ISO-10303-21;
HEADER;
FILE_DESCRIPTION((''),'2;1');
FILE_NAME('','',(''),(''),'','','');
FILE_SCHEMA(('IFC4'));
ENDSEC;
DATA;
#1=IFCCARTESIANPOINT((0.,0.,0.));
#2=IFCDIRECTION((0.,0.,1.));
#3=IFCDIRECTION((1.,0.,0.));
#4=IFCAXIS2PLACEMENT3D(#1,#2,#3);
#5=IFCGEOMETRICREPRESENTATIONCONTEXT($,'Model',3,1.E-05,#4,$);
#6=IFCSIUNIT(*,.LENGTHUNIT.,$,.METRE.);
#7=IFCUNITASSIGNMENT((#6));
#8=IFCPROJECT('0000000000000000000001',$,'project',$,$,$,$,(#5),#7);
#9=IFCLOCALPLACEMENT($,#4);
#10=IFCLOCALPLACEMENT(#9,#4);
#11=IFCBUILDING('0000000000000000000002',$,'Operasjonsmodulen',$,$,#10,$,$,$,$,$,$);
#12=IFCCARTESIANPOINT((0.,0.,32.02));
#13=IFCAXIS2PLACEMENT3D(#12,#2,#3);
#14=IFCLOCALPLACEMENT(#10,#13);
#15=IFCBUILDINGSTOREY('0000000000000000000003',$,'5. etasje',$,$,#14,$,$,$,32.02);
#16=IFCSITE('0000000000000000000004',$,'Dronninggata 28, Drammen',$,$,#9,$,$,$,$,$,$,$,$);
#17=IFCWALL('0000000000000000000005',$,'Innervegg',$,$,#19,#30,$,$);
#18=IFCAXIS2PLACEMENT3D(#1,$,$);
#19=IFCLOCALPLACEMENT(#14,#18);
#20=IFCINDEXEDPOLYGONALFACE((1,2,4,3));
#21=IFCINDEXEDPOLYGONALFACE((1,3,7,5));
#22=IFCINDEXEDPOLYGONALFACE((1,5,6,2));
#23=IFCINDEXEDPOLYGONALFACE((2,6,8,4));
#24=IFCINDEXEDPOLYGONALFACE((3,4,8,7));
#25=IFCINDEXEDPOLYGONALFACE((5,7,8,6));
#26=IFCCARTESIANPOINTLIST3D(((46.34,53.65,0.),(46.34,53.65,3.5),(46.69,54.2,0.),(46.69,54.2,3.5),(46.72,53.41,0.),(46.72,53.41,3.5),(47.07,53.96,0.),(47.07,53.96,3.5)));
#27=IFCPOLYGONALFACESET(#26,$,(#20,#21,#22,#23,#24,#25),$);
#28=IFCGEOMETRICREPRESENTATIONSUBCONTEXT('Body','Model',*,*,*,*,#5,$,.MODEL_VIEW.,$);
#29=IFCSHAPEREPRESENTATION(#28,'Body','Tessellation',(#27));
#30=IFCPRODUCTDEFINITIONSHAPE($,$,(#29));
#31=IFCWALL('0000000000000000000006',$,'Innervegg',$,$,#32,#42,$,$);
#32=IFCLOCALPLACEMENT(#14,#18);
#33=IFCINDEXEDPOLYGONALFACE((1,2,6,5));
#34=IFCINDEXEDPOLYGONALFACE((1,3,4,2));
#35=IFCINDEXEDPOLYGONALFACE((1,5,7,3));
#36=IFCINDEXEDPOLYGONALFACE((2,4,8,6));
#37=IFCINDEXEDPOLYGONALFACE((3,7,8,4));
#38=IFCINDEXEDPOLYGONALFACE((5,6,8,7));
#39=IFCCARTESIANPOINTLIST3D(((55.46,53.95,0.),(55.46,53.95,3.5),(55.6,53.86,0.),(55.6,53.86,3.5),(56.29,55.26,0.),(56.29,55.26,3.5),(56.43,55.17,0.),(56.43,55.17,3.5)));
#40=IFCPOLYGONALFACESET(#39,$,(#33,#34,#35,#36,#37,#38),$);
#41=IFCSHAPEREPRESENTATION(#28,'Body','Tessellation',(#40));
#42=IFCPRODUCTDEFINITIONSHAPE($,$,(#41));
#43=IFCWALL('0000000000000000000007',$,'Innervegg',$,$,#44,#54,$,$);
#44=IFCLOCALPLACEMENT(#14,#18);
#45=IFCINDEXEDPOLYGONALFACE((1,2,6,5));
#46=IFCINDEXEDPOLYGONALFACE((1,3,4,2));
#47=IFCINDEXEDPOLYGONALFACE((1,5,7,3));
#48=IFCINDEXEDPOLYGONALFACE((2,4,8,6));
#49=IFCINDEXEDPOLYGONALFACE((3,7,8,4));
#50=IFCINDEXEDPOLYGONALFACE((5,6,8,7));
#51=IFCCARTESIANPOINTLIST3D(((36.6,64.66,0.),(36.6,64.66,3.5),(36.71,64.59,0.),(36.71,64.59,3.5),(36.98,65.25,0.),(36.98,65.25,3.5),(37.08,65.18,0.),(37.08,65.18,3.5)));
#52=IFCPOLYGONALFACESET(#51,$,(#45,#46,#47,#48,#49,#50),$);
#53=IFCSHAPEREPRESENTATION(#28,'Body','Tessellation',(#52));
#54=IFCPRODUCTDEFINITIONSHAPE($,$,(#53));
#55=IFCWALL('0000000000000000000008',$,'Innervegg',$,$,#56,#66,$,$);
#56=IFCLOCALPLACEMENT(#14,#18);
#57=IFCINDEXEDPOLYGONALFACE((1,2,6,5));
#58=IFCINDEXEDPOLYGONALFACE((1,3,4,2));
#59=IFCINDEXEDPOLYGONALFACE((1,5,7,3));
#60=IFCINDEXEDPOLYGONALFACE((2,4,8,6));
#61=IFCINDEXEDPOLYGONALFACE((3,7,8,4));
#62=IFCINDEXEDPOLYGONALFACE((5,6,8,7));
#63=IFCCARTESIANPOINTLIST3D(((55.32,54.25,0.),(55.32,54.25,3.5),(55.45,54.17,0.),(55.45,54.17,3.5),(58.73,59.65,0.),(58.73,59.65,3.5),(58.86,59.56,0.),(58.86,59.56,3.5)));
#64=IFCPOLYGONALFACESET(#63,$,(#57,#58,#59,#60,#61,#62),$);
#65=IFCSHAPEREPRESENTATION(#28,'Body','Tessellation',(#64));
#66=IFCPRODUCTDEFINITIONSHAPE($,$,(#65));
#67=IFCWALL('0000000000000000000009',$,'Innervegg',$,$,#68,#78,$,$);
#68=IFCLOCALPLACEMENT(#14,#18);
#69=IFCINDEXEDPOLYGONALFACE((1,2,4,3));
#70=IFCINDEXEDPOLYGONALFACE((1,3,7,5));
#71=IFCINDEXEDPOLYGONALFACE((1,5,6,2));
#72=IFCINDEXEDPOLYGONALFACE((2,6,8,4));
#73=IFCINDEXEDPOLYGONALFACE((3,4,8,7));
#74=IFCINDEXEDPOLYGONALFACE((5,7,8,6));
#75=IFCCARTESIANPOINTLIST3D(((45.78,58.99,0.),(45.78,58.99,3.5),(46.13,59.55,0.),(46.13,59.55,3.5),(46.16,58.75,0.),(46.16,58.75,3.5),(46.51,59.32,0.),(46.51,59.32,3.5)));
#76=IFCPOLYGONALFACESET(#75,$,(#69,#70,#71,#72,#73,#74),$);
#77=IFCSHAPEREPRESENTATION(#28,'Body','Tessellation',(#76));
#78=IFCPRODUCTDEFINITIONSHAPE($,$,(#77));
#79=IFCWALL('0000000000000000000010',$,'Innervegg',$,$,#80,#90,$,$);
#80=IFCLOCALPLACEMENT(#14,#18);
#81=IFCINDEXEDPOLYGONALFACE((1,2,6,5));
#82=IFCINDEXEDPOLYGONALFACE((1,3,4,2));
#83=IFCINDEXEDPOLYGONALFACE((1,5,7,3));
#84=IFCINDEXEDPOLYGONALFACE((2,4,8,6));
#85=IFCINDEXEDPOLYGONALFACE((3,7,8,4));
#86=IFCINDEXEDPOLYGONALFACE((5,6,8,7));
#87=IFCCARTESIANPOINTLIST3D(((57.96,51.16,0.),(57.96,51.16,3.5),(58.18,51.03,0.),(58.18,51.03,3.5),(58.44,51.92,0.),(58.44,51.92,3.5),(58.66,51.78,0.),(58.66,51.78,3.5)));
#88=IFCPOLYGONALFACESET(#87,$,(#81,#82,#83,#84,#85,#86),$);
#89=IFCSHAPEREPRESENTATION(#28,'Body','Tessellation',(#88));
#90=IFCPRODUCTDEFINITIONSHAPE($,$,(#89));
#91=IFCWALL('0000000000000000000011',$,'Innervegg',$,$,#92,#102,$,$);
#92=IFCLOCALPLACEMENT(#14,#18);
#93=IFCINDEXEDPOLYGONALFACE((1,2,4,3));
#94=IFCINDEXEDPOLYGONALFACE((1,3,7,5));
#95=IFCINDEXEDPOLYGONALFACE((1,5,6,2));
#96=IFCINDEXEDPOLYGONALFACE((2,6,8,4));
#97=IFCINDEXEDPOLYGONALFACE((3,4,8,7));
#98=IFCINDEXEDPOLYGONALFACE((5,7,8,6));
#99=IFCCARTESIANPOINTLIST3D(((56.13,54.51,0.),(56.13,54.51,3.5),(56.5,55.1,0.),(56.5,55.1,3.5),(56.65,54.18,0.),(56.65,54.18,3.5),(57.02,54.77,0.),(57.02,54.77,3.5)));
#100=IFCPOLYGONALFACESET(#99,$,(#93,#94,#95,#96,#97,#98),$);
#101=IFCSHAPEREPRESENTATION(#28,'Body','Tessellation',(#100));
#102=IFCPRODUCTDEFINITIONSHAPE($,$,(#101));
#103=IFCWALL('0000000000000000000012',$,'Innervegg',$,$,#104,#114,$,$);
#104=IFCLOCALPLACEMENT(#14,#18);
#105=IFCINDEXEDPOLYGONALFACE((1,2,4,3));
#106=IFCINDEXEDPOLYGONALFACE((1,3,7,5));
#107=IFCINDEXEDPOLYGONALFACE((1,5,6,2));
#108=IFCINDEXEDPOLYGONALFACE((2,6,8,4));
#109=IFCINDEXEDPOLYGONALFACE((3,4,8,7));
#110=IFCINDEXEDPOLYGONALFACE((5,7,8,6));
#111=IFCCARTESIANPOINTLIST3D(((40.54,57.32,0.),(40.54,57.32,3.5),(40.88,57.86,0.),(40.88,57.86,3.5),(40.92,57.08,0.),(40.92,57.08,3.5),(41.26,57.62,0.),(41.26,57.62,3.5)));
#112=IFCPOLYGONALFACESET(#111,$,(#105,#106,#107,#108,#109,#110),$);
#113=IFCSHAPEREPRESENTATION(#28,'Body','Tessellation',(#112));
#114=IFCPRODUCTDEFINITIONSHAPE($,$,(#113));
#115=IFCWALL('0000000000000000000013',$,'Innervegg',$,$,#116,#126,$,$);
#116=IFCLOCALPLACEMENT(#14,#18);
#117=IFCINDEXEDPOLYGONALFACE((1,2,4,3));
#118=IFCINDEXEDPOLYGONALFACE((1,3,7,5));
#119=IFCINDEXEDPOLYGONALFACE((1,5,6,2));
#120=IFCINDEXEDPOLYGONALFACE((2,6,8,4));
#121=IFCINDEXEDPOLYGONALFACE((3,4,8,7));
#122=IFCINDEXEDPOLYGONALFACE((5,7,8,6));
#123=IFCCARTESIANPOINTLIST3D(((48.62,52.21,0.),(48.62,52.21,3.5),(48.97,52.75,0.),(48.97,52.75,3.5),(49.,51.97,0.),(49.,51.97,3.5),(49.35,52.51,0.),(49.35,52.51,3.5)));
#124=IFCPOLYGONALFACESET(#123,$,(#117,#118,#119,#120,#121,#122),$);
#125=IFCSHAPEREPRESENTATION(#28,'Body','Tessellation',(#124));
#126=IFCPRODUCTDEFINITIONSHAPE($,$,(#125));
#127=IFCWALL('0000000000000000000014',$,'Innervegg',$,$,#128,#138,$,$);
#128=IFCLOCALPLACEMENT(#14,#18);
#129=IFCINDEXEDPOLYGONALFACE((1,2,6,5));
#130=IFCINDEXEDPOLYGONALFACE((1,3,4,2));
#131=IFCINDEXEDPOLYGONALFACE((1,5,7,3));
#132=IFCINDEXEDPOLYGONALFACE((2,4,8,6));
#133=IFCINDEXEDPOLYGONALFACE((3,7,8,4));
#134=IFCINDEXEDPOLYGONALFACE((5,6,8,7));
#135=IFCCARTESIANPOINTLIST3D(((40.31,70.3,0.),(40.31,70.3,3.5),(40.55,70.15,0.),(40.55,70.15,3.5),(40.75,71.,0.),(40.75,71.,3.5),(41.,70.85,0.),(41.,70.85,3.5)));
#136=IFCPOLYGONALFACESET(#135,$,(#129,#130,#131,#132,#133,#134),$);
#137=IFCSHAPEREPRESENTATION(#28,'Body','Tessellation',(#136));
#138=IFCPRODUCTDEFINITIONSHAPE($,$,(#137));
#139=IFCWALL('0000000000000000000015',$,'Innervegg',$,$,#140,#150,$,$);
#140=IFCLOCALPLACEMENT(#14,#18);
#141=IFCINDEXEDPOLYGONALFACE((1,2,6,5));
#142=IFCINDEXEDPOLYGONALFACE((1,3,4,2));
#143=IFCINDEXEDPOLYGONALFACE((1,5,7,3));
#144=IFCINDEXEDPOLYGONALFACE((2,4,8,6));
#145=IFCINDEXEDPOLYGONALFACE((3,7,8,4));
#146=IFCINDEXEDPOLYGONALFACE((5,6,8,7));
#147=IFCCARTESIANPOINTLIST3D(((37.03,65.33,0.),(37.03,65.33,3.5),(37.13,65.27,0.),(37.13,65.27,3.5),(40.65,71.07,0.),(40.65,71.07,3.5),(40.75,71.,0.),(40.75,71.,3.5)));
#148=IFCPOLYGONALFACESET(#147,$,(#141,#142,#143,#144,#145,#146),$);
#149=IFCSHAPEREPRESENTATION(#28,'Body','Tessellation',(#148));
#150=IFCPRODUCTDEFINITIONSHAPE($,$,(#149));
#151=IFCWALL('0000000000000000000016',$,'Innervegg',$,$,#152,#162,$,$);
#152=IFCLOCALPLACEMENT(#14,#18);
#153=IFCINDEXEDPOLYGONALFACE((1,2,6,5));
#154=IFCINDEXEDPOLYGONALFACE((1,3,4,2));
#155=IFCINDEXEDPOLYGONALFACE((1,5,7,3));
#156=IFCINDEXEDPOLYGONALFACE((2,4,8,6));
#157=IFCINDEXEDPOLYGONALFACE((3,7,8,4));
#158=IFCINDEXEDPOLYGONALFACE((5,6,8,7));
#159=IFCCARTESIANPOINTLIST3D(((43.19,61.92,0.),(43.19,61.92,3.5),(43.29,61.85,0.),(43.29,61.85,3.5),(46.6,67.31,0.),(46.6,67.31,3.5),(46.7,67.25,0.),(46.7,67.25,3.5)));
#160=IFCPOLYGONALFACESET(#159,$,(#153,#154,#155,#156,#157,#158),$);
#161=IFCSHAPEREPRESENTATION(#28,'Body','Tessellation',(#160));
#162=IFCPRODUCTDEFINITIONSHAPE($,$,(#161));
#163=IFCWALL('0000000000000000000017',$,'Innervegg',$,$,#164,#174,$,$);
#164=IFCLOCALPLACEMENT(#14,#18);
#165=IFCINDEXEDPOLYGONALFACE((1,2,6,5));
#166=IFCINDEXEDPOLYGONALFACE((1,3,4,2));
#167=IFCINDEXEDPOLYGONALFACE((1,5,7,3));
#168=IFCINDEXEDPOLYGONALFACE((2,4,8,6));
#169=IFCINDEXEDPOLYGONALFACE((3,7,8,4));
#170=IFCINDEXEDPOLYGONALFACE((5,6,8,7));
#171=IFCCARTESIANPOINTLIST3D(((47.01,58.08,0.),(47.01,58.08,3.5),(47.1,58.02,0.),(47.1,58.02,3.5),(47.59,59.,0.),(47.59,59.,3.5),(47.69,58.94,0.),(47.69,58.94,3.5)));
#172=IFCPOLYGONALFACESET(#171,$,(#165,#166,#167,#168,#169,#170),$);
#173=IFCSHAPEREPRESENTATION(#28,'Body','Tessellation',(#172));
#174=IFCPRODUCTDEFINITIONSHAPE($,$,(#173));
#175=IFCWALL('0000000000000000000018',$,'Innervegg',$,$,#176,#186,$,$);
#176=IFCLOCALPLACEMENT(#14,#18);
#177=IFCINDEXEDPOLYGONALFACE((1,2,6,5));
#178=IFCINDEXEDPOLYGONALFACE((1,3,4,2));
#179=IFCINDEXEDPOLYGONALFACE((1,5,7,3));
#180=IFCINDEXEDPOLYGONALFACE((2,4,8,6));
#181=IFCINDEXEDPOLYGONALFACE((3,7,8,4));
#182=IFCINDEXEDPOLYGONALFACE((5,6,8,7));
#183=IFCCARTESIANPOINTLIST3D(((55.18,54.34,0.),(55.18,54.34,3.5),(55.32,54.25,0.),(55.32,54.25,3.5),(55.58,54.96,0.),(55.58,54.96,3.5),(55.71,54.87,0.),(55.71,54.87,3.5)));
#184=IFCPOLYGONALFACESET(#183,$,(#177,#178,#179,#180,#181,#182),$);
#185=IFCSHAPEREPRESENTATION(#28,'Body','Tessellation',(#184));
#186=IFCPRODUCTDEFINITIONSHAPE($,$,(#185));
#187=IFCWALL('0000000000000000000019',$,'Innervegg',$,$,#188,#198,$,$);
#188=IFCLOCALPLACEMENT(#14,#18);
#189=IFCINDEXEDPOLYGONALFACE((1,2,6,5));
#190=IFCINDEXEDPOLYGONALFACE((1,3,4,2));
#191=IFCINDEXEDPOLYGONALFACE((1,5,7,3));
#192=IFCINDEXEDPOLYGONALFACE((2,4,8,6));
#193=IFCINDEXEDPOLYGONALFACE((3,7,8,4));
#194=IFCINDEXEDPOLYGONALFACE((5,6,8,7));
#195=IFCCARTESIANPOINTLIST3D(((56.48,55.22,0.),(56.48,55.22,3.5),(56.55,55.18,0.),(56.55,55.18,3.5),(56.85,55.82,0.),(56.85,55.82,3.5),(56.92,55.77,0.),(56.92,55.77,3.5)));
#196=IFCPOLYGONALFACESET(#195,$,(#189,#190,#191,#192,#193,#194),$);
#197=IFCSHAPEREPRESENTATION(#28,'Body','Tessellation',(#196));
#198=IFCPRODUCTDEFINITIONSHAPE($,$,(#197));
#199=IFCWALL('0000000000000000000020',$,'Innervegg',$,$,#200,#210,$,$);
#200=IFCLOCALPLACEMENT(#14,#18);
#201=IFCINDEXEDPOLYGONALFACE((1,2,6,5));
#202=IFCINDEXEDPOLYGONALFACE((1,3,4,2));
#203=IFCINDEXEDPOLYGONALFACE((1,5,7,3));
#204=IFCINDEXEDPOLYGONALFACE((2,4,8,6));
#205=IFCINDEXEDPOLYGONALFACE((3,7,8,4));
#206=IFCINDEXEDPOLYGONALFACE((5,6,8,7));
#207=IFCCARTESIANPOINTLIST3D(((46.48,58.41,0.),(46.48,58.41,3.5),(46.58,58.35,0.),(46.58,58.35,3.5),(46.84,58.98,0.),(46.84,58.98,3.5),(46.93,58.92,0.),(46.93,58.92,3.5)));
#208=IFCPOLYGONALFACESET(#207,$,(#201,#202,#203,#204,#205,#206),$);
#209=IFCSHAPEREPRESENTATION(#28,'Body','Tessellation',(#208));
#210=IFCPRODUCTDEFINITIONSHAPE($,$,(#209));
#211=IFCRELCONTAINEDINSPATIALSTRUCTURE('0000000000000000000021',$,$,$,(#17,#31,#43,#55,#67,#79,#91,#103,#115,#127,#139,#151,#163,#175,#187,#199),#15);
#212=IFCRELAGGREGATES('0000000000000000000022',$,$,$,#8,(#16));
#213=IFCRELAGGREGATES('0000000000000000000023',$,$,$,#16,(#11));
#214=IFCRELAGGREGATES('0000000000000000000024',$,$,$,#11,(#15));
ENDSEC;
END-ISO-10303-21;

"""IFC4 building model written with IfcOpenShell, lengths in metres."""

from ifc_helpers import new_model, si_unit, frame, origin_with_axes, place, context, subcontext, project, spatial, polyline, outline, extrude, element, save


model = new_model("IFC4")

# Units and contexts
model_context = context("Model", 3, precision=1e-05, world=origin_with_axes())
body_context = subcontext(model_context, "Body", "Model", "MODEL_VIEW")
ifc_project = project(units=[si_unit("LENGTHUNIT", "METRE")], contexts=[model_context])

# Site, building, storey
site_placement = place(None, origin_with_axes())
site = spatial("IfcSite", under=ifc_project, at=site_placement, Name="Dronninggata 28, Drammen")
building_placement = place(site_placement, origin_with_axes())
building = spatial("IfcBuilding", under=site, at=building_placement, Name="Operasjonsmodulen")
storey_placement = place(building_placement, frame((0.0, 0.0, 32.02), z_axis=(0.0, 0.0, 1.0), x_axis=(1.0, 0.0, 0.0)))
storey = spatial("IfcBuildingStorey", under=building, at=storey_placement, Name="5. etasje", Elevation=32.02)

# Walls
wall_1_placement = place(storey_placement, frame((0.0, 0.0, -32.02), z_axis=(0.0, 0.0, 1.0), x_axis=(1.0, 0.0, 0.0)))
element("IfcWall", 1, at=wall_1_placement, inside=storey, Name="Innervegg", context=body_context, shape_type="SweptSolid", body=[
    extrude(outline(polyline([(47.07, 53.96), (46.72, 53.41), (46.34, 53.65), (46.69, 54.2), (47.07, 53.96)])), frame((0.0, 0.0, 32.02)), (0.0, 0.0, 1.0), 3.5),
])
wall_2_placement = place(storey_placement, frame((0.0, 0.0, -32.02), z_axis=(0.0, 0.0, 1.0), x_axis=(1.0, 0.0, 0.0)))
element("IfcWall", 2, at=wall_2_placement, inside=storey, Name="Innervegg", context=body_context, shape_type="SweptSolid", body=[
    extrude(outline(polyline([(56.43, 55.17), (55.6, 53.86), (55.46, 53.95), (56.29, 55.26), (56.43, 55.17)])), frame((0.0, 0.0, 32.02)), (0.0, 0.0, 1.0), 3.5),
])
wall_3_placement = place(storey_placement, frame((0.0, 0.0, -32.02), z_axis=(0.0, 0.0, 1.0), x_axis=(1.0, 0.0, 0.0)))
element("IfcWall", 3, at=wall_3_placement, inside=storey, Name="Innervegg", context=body_context, shape_type="SweptSolid", body=[
    extrude(outline(polyline([(37.08, 65.18), (36.71, 64.59), (36.6, 64.66), (36.98, 65.25), (37.08, 65.18)])), frame((0.0, 0.0, 32.02)), (0.0, 0.0, 1.0), 3.5),
])
wall_4_placement = place(storey_placement, frame((0.0, 0.0, -32.02), z_axis=(0.0, 0.0, 1.0), x_axis=(1.0, 0.0, 0.0)))
element("IfcWall", 4, at=wall_4_placement, inside=storey, Name="Innervegg", context=body_context, shape_type="SweptSolid", body=[
    extrude(outline(polyline([(58.86, 59.56), (55.45, 54.17), (55.32, 54.25), (58.73, 59.65), (58.86, 59.56)])), frame((0.0, 0.0, 32.02)), (0.0, 0.0, 1.0), 3.5),
])
wall_5_placement = place(storey_placement, frame((0.0, 0.0, -32.02), z_axis=(0.0, 0.0, 1.0), x_axis=(1.0, 0.0, 0.0)))
element("IfcWall", 5, at=wall_5_placement, inside=storey, Name="Innervegg", context=body_context, shape_type="SweptSolid", body=[
    extrude(outline(polyline([(46.51, 59.32), (46.16, 58.75), (45.78, 58.99), (46.13, 59.55), (46.51, 59.32)])), frame((0.0, 0.0, 32.02)), (0.0, 0.0, 1.0), 3.5),
])
wall_6_placement = place(storey_placement, frame((0.0, 0.0, -32.02), z_axis=(0.0, 0.0, 1.0), x_axis=(1.0, 0.0, 0.0)))
element("IfcWall", 6, at=wall_6_placement, inside=storey, Name="Innervegg", context=body_context, shape_type="SweptSolid", body=[
    extrude(outline(polyline([(58.66, 51.78), (58.18, 51.03), (57.96, 51.16), (58.44, 51.92), (58.66, 51.78)])), frame((0.0, 0.0, 32.02)), (0.0, 0.0, 1.0), 3.5),
])
wall_7_placement = place(storey_placement, frame((0.0, 0.0, -32.02), z_axis=(0.0, 0.0, 1.0), x_axis=(1.0, 0.0, 0.0)))
element("IfcWall", 7, at=wall_7_placement, inside=storey, Name="Innervegg", context=body_context, shape_type="SweptSolid", body=[
    extrude(outline(polyline([(57.02, 54.77), (56.65, 54.18), (56.13, 54.51), (56.5, 55.1), (57.02, 54.77)])), frame((0.0, 0.0, 32.02)), (0.0, 0.0, 1.0), 3.5),
])
wall_8_placement = place(storey_placement, frame((0.0, 0.0, -32.02), z_axis=(0.0, 0.0, 1.0), x_axis=(1.0, 0.0, 0.0)))
element("IfcWall", 8, at=wall_8_placement, inside=storey, Name="Innervegg", context=body_context, shape_type="SweptSolid", body=[
    extrude(outline(polyline([(41.26, 57.62), (40.92, 57.08), (40.54, 57.32), (40.88, 57.86), (41.26, 57.62)])), frame((0.0, 0.0, 32.02)), (0.0, 0.0, 1.0), 3.5),
])
wall_9_placement = place(storey_placement, frame((0.0, 0.0, -32.02), z_axis=(0.0, 0.0, 1.0), x_axis=(1.0, 0.0, 0.0)))
element("IfcWall", 9, at=wall_9_placement, inside=storey, Name="Innervegg", context=body_context, shape_type="SweptSolid", body=[
    extrude(outline(polyline([(49.35, 52.51), (49.0, 51.97), (48.62, 52.21), (48.97, 52.75), (49.35, 52.51)])), frame((0.0, 0.0, 32.02)), (0.0, 0.0, 1.0), 3.5),
])
wall_10_placement = place(storey_placement, frame((0.0, 0.0, -32.02), z_axis=(0.0, 0.0, 1.0), x_axis=(1.0, 0.0, 0.0)))
element("IfcWall", 10, at=wall_10_placement, inside=storey, Name="Innervegg", context=body_context, shape_type="SweptSolid", body=[
    extrude(outline(polyline([(41.0, 70.85), (40.55, 70.15), (40.31, 70.3), (40.75, 71.0), (41.0, 70.85)])), frame((0.0, 0.0, 32.02)), (0.0, 0.0, 1.0), 3.5),
])
wall_11_placement = place(storey_placement, frame((0.0, 0.0, -32.02), z_axis=(0.0, 0.0, 1.0), x_axis=(1.0, 0.0, 0.0)))
element("IfcWall", 11, at=wall_11_placement, inside=storey, Name="Innervegg", context=body_context, shape_type="SweptSolid", body=[
    extrude(outline(polyline([(40.75, 71.0), (37.13, 65.27), (37.03, 65.33), (40.65, 71.07), (40.75, 71.0)])), frame((0.0, 0.0, 32.02)), (0.0, 0.0, 1.0), 3.5),
])
wall_12_placement = place(storey_placement, frame((0.0, 0.0, -32.02), z_axis=(0.0, 0.0, 1.0), x_axis=(1.0, 0.0, 0.0)))
element("IfcWall", 12, at=wall_12_placement, inside=storey, Name="Innervegg", context=body_context, shape_type="SweptSolid", body=[
    extrude(outline(polyline([(46.7, 67.25), (43.29, 61.85), (43.19, 61.92), (46.6, 67.31), (46.7, 67.25)])), frame((0.0, 0.0, 32.02)), (0.0, 0.0, 1.0), 3.5),
])
wall_13_placement = place(storey_placement, frame((0.0, 0.0, -32.02), z_axis=(0.0, 0.0, 1.0), x_axis=(1.0, 0.0, 0.0)))
element("IfcWall", 13, at=wall_13_placement, inside=storey, Name="Innervegg", context=body_context, shape_type="SweptSolid", body=[
    extrude(outline(polyline([(47.69, 58.94), (47.1, 58.02), (47.01, 58.08), (47.59, 59.0), (47.69, 58.94)])), frame((0.0, 0.0, 32.02)), (0.0, 0.0, 1.0), 3.5),
])
wall_14_placement = place(storey_placement, frame((0.0, 0.0, -32.02), z_axis=(0.0, 0.0, 1.0), x_axis=(1.0, 0.0, 0.0)))
element("IfcWall", 14, at=wall_14_placement, inside=storey, Name="Innervegg", context=body_context, shape_type="SweptSolid", body=[
    extrude(outline(polyline([(55.71, 54.87), (55.32, 54.25), (55.18, 54.34), (55.58, 54.96), (55.71, 54.87)])), frame((0.0, 0.0, 32.02)), (0.0, 0.0, 1.0), 3.5),
])
wall_15_placement = place(storey_placement, frame((0.0, 0.0, -32.02), z_axis=(0.0, 0.0, 1.0), x_axis=(1.0, 0.0, 0.0)))
element("IfcWall", 15, at=wall_15_placement, inside=storey, Name="Innervegg", context=body_context, shape_type="SweptSolid", body=[
    extrude(outline(polyline([(56.92, 55.77), (56.55, 55.18), (56.48, 55.22), (56.85, 55.82), (56.92, 55.77)])), frame((0.0, 0.0, 32.02)), (0.0, 0.0, 1.0), 3.5),
])
wall_16_placement = place(storey_placement, frame((0.0, 0.0, -32.02), z_axis=(0.0, 0.0, 1.0), x_axis=(1.0, 0.0, 0.0)))
element("IfcWall", 16, at=wall_16_placement, inside=storey, Name="Innervegg", context=body_context, shape_type="SweptSolid", body=[
    extrude(outline(polyline([(46.93, 58.92), (46.58, 58.35), (46.48, 58.41), (46.84, 58.98), (46.93, 58.92)])), frame((0.0, 0.0, 32.02)), (0.0, 0.0, 1.0), 3.5),
])

save(model, "model.ifc")
